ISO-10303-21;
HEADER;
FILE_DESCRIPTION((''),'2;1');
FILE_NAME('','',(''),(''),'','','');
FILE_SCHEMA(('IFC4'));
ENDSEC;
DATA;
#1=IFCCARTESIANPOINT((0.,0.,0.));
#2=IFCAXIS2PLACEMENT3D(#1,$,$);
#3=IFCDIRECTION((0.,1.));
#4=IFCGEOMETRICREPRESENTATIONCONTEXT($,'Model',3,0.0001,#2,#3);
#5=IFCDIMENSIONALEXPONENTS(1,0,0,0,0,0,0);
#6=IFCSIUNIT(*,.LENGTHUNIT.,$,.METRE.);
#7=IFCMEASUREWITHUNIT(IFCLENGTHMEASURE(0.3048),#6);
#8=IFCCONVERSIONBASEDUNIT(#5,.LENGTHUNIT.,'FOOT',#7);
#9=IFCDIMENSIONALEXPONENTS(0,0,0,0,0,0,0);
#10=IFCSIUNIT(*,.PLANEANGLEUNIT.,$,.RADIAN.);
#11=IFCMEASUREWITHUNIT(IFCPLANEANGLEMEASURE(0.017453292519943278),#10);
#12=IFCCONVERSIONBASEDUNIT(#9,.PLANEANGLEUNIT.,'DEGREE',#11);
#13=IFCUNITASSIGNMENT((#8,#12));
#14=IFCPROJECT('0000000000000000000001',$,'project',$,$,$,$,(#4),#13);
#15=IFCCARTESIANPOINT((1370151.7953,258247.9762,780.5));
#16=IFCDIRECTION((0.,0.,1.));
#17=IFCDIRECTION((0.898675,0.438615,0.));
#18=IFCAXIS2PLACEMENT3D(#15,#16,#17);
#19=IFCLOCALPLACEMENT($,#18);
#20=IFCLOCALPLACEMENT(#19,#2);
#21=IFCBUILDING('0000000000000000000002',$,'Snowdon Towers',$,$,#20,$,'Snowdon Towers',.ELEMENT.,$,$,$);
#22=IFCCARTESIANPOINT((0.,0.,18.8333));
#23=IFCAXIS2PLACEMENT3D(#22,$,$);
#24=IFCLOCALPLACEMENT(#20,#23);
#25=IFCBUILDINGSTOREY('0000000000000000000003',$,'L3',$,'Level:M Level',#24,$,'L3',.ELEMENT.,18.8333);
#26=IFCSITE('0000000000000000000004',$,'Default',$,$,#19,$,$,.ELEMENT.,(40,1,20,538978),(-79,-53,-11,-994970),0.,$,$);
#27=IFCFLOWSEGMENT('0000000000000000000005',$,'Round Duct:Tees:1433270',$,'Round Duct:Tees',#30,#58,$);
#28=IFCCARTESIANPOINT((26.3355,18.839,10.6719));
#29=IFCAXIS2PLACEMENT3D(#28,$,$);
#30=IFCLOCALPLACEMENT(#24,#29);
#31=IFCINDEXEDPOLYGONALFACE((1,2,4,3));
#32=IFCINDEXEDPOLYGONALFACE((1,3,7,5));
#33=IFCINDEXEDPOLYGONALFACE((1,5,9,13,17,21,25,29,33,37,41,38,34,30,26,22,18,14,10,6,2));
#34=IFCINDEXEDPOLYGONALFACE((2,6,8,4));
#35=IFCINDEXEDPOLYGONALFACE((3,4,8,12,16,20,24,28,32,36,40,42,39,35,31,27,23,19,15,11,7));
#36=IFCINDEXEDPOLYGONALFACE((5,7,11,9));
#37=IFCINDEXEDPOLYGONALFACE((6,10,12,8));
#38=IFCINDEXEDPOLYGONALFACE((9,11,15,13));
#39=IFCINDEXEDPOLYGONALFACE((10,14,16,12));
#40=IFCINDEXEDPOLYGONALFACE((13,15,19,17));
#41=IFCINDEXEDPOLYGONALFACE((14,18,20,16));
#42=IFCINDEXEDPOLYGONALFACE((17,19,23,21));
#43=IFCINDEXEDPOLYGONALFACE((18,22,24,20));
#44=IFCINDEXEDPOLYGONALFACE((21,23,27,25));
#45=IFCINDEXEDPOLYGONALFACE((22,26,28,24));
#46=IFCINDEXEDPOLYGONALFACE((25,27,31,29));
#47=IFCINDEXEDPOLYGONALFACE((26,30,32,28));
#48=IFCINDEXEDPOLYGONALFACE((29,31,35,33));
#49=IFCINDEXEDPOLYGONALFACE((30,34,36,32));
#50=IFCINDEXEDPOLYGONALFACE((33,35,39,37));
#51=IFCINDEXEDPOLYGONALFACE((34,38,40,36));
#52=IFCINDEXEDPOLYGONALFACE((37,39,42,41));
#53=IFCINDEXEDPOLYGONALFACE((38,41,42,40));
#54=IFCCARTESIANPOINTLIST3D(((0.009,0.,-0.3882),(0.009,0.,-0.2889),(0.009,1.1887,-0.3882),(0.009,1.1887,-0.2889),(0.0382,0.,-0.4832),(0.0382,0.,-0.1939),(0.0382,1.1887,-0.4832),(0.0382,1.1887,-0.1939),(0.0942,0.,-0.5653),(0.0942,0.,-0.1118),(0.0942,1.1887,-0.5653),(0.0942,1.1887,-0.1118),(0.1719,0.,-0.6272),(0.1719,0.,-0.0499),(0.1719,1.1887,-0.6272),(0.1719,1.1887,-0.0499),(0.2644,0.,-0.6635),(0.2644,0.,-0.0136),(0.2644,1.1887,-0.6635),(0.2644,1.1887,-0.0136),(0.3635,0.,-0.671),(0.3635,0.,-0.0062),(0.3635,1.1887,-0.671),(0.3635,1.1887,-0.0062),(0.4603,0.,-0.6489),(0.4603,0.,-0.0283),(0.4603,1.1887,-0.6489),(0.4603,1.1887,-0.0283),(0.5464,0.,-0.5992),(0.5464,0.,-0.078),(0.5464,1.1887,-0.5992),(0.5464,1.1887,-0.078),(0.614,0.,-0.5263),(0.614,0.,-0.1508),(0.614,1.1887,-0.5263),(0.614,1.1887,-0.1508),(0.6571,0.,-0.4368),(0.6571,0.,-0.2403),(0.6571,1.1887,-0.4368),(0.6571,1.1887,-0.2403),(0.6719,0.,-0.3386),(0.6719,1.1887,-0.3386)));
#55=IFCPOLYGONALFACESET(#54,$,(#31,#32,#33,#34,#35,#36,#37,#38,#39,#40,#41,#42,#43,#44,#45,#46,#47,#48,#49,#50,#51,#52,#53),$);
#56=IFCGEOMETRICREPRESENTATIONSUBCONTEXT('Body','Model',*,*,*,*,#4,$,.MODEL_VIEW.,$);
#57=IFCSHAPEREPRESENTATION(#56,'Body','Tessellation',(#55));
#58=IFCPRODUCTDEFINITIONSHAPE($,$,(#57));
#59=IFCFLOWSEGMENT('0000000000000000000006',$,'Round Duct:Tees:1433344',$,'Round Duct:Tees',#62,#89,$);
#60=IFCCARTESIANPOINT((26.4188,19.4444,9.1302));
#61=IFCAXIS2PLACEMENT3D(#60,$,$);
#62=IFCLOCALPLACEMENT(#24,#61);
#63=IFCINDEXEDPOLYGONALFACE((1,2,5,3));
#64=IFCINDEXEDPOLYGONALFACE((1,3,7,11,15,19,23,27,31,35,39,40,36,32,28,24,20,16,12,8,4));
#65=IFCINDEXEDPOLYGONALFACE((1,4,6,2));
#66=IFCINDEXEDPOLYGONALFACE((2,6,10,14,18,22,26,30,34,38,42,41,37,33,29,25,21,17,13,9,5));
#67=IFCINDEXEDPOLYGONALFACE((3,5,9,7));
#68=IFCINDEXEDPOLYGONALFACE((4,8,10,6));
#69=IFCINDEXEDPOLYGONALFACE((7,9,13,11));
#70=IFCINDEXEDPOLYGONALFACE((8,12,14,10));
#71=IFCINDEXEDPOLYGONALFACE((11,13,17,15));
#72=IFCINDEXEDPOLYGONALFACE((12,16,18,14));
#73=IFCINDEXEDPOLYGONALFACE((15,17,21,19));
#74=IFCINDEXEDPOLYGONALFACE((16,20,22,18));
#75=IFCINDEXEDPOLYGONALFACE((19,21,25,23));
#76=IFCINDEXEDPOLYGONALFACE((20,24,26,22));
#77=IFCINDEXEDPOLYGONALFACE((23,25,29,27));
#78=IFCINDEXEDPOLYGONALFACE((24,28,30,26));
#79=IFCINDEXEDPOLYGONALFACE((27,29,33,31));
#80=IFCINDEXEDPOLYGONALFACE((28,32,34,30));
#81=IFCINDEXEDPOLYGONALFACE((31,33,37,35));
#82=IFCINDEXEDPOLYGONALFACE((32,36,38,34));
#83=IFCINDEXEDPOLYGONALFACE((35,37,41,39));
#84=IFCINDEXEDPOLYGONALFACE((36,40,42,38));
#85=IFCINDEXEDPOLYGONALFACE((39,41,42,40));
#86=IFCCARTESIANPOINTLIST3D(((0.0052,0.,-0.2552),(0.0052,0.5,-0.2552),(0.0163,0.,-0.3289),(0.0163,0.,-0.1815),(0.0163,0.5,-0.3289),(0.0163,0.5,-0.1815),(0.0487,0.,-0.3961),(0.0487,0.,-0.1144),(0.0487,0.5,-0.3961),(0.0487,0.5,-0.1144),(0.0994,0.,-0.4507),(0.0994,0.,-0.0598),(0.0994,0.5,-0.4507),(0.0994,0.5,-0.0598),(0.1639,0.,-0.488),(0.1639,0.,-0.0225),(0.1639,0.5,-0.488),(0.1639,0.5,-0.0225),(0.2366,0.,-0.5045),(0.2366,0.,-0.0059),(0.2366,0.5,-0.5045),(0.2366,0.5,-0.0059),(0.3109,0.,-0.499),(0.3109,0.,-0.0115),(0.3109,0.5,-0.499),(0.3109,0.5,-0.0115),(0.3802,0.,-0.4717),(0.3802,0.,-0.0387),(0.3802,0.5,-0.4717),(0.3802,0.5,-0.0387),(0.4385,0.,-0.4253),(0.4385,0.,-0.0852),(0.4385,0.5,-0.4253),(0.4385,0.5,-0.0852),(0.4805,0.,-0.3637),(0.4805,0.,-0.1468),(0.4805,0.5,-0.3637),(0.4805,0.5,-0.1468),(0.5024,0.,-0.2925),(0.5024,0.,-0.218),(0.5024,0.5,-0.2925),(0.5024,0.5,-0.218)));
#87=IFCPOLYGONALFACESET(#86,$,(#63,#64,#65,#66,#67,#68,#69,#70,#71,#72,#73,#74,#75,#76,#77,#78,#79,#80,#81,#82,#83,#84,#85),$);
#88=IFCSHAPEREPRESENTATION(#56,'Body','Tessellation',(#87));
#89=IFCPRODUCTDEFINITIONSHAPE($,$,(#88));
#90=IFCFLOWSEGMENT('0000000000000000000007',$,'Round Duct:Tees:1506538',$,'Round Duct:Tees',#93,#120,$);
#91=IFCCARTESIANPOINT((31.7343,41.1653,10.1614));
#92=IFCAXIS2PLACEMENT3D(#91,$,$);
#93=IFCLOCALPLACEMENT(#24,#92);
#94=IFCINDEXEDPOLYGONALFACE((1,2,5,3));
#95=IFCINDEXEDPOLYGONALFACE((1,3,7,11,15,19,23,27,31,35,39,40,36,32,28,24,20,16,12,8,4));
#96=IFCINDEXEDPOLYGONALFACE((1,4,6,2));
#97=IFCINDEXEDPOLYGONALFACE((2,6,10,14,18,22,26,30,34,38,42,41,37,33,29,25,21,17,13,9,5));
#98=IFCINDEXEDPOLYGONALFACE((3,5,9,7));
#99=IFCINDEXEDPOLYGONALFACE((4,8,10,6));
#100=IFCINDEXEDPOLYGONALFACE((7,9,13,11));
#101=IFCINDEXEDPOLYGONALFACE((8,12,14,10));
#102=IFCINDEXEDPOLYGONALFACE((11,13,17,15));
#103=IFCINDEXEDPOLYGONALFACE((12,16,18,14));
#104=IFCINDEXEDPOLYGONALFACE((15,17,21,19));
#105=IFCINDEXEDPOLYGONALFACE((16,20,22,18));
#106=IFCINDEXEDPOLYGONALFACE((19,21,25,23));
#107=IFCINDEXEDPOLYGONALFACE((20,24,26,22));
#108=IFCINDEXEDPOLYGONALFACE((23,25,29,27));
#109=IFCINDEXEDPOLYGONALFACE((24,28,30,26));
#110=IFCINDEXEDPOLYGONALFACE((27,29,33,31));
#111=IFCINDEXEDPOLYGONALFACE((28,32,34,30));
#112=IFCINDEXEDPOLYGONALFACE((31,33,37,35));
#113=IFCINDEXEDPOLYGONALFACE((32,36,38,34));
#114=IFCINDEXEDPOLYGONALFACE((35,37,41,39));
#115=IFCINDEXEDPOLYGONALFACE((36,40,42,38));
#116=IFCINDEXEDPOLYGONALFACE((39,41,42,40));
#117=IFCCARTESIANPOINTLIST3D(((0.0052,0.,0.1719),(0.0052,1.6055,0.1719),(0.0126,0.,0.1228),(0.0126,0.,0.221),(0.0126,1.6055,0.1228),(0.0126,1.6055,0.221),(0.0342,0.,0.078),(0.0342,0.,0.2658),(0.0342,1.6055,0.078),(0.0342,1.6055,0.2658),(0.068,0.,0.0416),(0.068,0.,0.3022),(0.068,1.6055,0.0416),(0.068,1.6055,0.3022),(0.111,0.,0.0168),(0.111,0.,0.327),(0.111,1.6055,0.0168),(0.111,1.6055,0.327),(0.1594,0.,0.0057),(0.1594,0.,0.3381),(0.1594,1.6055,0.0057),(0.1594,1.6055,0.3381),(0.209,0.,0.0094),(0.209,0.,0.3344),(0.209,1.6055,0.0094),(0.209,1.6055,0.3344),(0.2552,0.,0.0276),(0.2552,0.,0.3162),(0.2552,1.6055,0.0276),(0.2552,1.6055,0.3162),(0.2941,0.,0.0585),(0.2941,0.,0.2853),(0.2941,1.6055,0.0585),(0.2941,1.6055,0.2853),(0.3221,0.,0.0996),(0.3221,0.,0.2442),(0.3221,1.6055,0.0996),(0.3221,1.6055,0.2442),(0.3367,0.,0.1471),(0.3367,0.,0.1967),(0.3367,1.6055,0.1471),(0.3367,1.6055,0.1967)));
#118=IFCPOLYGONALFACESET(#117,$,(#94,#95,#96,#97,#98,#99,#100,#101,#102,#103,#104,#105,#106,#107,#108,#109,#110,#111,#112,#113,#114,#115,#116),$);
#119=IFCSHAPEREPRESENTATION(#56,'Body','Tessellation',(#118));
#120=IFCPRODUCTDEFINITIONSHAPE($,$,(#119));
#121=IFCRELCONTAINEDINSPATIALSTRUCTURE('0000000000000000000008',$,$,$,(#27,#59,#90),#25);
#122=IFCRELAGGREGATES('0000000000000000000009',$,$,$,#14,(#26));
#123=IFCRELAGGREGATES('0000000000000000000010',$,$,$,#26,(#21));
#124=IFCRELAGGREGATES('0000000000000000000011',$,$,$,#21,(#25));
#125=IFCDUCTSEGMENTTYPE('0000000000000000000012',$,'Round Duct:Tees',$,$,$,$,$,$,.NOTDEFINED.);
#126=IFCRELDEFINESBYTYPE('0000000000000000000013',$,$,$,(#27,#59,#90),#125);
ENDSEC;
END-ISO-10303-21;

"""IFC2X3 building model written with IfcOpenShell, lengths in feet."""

from ifc_helpers import new_model, entity, si_unit, converted_unit, direction, frame, frame_2d, origin, place, context, subcontext, project, spatial, circle, extrude, type_object, element, save


model = new_model("IFC2X3")

# Units and contexts
model_context = context("Model", 3, precision=0.0001, world=origin(), true_north=direction((0.0, 1.0)))
body_context = subcontext(model_context, "Body", "Model", "MODEL_VIEW")
ifc_project = project(units=[converted_unit("LENGTHUNIT", "FOOT", entity("IfcLengthMeasure", 0.3048), si_unit("LENGTHUNIT", "METRE"), dimensions=[1, 0, 0, 0, 0, 0, 0]), converted_unit("PLANEANGLEUNIT", "DEGREE", entity("IfcPlaneAngleMeasure", 0.017453292519943278), si_unit("PLANEANGLEUNIT", "RADIAN"), dimensions=[0, 0, 0, 0, 0, 0, 0])], contexts=[model_context])

# Site, building, storey
site_placement = place(None, frame((1370151.7953, 258247.9762, 780.5), z_axis=(0.0, 0.0, 1.0), x_axis=(0.898675, 0.438615, 0.0)))
site = spatial("IfcSite", under=ifc_project, at=site_placement, Name="Default", CompositionType="ELEMENT", RefLatitude=(40, 1, 20, 538978), RefLongitude=(-79, -53, -11, -994970), RefElevation=0.0)
building_placement = place(site_placement, origin())
building = spatial("IfcBuilding", under=site, at=building_placement, Name="Snowdon Towers", LongName="Snowdon Towers", CompositionType="ELEMENT")
storey_placement = place(building_placement, frame((0.0, 0.0, 18.8333)))
storey = spatial("IfcBuildingStorey", under=building, at=storey_placement, Name="L3", ObjectType="Level:M Level", LongName="L3", CompositionType="ELEMENT", Elevation=18.8333)

# Flow segments
duct_segment_type = type_object("IfcDuctSegmentType", Name="Round Duct:Tees", PredefinedType="NOTDEFINED")
flow_segment_1_placement = place(storey_placement, frame((26.3355, 18.839, 10.6719)))
element("IfcFlowSegment", 1, at=flow_segment_1_placement, inside=storey, type_object=duct_segment_type, Name="Round Duct:Tees:1433270", ObjectType="Round Duct:Tees", context=body_context, shape_type="SweptSolid", body=[
    extrude(circle(Radius=0.3333, at=frame_2d((0.0, 0.0), x_axis=(1.0, 0.0))), frame((0.3386, 0.0, -0.3386), z_axis=(0.0, 1.0, 0.0), x_axis=(1.0, 0.0, 0.0)), (0.0, 0.0, 1.0), 1.1887),
])
flow_segment_2_placement = place(storey_placement, frame((26.4188, 19.4444, 9.1302)))
element("IfcFlowSegment", 2, at=flow_segment_2_placement, inside=storey, type_object=duct_segment_type, Name="Round Duct:Tees:1433344", ObjectType="Round Duct:Tees", context=body_context, shape_type="SweptSolid", body=[
    extrude(circle(Radius=0.25, at=frame_2d((0.0, 0.0), x_axis=(1.0, 0.0))), frame((0.2552, 0.0, -0.2552), z_axis=(0.0, 1.0, 0.0), x_axis=(-1.0, 0.0, 0.0)), (0.0, 0.0, 1.0), 0.5),
])
flow_segment_3_placement = place(storey_placement, frame((31.7343, 41.1653, 10.1614)))
element("IfcFlowSegment", 3, at=flow_segment_3_placement, inside=storey, type_object=duct_segment_type, Name="Round Duct:Tees:1506538", ObjectType="Round Duct:Tees", context=body_context, shape_type="SweptSolid", body=[
    extrude(circle(Radius=0.1667, at=frame_2d((0.0, 0.0), x_axis=(1.0, 0.0))), frame((0.1719, 0.0, 0.1719), z_axis=(0.0, 1.0, 0.0), x_axis=(-1.0, 0.0, 0.0)), (0.0, 0.0, 1.0), 1.6055),
])

save(model, "model.ifc")
